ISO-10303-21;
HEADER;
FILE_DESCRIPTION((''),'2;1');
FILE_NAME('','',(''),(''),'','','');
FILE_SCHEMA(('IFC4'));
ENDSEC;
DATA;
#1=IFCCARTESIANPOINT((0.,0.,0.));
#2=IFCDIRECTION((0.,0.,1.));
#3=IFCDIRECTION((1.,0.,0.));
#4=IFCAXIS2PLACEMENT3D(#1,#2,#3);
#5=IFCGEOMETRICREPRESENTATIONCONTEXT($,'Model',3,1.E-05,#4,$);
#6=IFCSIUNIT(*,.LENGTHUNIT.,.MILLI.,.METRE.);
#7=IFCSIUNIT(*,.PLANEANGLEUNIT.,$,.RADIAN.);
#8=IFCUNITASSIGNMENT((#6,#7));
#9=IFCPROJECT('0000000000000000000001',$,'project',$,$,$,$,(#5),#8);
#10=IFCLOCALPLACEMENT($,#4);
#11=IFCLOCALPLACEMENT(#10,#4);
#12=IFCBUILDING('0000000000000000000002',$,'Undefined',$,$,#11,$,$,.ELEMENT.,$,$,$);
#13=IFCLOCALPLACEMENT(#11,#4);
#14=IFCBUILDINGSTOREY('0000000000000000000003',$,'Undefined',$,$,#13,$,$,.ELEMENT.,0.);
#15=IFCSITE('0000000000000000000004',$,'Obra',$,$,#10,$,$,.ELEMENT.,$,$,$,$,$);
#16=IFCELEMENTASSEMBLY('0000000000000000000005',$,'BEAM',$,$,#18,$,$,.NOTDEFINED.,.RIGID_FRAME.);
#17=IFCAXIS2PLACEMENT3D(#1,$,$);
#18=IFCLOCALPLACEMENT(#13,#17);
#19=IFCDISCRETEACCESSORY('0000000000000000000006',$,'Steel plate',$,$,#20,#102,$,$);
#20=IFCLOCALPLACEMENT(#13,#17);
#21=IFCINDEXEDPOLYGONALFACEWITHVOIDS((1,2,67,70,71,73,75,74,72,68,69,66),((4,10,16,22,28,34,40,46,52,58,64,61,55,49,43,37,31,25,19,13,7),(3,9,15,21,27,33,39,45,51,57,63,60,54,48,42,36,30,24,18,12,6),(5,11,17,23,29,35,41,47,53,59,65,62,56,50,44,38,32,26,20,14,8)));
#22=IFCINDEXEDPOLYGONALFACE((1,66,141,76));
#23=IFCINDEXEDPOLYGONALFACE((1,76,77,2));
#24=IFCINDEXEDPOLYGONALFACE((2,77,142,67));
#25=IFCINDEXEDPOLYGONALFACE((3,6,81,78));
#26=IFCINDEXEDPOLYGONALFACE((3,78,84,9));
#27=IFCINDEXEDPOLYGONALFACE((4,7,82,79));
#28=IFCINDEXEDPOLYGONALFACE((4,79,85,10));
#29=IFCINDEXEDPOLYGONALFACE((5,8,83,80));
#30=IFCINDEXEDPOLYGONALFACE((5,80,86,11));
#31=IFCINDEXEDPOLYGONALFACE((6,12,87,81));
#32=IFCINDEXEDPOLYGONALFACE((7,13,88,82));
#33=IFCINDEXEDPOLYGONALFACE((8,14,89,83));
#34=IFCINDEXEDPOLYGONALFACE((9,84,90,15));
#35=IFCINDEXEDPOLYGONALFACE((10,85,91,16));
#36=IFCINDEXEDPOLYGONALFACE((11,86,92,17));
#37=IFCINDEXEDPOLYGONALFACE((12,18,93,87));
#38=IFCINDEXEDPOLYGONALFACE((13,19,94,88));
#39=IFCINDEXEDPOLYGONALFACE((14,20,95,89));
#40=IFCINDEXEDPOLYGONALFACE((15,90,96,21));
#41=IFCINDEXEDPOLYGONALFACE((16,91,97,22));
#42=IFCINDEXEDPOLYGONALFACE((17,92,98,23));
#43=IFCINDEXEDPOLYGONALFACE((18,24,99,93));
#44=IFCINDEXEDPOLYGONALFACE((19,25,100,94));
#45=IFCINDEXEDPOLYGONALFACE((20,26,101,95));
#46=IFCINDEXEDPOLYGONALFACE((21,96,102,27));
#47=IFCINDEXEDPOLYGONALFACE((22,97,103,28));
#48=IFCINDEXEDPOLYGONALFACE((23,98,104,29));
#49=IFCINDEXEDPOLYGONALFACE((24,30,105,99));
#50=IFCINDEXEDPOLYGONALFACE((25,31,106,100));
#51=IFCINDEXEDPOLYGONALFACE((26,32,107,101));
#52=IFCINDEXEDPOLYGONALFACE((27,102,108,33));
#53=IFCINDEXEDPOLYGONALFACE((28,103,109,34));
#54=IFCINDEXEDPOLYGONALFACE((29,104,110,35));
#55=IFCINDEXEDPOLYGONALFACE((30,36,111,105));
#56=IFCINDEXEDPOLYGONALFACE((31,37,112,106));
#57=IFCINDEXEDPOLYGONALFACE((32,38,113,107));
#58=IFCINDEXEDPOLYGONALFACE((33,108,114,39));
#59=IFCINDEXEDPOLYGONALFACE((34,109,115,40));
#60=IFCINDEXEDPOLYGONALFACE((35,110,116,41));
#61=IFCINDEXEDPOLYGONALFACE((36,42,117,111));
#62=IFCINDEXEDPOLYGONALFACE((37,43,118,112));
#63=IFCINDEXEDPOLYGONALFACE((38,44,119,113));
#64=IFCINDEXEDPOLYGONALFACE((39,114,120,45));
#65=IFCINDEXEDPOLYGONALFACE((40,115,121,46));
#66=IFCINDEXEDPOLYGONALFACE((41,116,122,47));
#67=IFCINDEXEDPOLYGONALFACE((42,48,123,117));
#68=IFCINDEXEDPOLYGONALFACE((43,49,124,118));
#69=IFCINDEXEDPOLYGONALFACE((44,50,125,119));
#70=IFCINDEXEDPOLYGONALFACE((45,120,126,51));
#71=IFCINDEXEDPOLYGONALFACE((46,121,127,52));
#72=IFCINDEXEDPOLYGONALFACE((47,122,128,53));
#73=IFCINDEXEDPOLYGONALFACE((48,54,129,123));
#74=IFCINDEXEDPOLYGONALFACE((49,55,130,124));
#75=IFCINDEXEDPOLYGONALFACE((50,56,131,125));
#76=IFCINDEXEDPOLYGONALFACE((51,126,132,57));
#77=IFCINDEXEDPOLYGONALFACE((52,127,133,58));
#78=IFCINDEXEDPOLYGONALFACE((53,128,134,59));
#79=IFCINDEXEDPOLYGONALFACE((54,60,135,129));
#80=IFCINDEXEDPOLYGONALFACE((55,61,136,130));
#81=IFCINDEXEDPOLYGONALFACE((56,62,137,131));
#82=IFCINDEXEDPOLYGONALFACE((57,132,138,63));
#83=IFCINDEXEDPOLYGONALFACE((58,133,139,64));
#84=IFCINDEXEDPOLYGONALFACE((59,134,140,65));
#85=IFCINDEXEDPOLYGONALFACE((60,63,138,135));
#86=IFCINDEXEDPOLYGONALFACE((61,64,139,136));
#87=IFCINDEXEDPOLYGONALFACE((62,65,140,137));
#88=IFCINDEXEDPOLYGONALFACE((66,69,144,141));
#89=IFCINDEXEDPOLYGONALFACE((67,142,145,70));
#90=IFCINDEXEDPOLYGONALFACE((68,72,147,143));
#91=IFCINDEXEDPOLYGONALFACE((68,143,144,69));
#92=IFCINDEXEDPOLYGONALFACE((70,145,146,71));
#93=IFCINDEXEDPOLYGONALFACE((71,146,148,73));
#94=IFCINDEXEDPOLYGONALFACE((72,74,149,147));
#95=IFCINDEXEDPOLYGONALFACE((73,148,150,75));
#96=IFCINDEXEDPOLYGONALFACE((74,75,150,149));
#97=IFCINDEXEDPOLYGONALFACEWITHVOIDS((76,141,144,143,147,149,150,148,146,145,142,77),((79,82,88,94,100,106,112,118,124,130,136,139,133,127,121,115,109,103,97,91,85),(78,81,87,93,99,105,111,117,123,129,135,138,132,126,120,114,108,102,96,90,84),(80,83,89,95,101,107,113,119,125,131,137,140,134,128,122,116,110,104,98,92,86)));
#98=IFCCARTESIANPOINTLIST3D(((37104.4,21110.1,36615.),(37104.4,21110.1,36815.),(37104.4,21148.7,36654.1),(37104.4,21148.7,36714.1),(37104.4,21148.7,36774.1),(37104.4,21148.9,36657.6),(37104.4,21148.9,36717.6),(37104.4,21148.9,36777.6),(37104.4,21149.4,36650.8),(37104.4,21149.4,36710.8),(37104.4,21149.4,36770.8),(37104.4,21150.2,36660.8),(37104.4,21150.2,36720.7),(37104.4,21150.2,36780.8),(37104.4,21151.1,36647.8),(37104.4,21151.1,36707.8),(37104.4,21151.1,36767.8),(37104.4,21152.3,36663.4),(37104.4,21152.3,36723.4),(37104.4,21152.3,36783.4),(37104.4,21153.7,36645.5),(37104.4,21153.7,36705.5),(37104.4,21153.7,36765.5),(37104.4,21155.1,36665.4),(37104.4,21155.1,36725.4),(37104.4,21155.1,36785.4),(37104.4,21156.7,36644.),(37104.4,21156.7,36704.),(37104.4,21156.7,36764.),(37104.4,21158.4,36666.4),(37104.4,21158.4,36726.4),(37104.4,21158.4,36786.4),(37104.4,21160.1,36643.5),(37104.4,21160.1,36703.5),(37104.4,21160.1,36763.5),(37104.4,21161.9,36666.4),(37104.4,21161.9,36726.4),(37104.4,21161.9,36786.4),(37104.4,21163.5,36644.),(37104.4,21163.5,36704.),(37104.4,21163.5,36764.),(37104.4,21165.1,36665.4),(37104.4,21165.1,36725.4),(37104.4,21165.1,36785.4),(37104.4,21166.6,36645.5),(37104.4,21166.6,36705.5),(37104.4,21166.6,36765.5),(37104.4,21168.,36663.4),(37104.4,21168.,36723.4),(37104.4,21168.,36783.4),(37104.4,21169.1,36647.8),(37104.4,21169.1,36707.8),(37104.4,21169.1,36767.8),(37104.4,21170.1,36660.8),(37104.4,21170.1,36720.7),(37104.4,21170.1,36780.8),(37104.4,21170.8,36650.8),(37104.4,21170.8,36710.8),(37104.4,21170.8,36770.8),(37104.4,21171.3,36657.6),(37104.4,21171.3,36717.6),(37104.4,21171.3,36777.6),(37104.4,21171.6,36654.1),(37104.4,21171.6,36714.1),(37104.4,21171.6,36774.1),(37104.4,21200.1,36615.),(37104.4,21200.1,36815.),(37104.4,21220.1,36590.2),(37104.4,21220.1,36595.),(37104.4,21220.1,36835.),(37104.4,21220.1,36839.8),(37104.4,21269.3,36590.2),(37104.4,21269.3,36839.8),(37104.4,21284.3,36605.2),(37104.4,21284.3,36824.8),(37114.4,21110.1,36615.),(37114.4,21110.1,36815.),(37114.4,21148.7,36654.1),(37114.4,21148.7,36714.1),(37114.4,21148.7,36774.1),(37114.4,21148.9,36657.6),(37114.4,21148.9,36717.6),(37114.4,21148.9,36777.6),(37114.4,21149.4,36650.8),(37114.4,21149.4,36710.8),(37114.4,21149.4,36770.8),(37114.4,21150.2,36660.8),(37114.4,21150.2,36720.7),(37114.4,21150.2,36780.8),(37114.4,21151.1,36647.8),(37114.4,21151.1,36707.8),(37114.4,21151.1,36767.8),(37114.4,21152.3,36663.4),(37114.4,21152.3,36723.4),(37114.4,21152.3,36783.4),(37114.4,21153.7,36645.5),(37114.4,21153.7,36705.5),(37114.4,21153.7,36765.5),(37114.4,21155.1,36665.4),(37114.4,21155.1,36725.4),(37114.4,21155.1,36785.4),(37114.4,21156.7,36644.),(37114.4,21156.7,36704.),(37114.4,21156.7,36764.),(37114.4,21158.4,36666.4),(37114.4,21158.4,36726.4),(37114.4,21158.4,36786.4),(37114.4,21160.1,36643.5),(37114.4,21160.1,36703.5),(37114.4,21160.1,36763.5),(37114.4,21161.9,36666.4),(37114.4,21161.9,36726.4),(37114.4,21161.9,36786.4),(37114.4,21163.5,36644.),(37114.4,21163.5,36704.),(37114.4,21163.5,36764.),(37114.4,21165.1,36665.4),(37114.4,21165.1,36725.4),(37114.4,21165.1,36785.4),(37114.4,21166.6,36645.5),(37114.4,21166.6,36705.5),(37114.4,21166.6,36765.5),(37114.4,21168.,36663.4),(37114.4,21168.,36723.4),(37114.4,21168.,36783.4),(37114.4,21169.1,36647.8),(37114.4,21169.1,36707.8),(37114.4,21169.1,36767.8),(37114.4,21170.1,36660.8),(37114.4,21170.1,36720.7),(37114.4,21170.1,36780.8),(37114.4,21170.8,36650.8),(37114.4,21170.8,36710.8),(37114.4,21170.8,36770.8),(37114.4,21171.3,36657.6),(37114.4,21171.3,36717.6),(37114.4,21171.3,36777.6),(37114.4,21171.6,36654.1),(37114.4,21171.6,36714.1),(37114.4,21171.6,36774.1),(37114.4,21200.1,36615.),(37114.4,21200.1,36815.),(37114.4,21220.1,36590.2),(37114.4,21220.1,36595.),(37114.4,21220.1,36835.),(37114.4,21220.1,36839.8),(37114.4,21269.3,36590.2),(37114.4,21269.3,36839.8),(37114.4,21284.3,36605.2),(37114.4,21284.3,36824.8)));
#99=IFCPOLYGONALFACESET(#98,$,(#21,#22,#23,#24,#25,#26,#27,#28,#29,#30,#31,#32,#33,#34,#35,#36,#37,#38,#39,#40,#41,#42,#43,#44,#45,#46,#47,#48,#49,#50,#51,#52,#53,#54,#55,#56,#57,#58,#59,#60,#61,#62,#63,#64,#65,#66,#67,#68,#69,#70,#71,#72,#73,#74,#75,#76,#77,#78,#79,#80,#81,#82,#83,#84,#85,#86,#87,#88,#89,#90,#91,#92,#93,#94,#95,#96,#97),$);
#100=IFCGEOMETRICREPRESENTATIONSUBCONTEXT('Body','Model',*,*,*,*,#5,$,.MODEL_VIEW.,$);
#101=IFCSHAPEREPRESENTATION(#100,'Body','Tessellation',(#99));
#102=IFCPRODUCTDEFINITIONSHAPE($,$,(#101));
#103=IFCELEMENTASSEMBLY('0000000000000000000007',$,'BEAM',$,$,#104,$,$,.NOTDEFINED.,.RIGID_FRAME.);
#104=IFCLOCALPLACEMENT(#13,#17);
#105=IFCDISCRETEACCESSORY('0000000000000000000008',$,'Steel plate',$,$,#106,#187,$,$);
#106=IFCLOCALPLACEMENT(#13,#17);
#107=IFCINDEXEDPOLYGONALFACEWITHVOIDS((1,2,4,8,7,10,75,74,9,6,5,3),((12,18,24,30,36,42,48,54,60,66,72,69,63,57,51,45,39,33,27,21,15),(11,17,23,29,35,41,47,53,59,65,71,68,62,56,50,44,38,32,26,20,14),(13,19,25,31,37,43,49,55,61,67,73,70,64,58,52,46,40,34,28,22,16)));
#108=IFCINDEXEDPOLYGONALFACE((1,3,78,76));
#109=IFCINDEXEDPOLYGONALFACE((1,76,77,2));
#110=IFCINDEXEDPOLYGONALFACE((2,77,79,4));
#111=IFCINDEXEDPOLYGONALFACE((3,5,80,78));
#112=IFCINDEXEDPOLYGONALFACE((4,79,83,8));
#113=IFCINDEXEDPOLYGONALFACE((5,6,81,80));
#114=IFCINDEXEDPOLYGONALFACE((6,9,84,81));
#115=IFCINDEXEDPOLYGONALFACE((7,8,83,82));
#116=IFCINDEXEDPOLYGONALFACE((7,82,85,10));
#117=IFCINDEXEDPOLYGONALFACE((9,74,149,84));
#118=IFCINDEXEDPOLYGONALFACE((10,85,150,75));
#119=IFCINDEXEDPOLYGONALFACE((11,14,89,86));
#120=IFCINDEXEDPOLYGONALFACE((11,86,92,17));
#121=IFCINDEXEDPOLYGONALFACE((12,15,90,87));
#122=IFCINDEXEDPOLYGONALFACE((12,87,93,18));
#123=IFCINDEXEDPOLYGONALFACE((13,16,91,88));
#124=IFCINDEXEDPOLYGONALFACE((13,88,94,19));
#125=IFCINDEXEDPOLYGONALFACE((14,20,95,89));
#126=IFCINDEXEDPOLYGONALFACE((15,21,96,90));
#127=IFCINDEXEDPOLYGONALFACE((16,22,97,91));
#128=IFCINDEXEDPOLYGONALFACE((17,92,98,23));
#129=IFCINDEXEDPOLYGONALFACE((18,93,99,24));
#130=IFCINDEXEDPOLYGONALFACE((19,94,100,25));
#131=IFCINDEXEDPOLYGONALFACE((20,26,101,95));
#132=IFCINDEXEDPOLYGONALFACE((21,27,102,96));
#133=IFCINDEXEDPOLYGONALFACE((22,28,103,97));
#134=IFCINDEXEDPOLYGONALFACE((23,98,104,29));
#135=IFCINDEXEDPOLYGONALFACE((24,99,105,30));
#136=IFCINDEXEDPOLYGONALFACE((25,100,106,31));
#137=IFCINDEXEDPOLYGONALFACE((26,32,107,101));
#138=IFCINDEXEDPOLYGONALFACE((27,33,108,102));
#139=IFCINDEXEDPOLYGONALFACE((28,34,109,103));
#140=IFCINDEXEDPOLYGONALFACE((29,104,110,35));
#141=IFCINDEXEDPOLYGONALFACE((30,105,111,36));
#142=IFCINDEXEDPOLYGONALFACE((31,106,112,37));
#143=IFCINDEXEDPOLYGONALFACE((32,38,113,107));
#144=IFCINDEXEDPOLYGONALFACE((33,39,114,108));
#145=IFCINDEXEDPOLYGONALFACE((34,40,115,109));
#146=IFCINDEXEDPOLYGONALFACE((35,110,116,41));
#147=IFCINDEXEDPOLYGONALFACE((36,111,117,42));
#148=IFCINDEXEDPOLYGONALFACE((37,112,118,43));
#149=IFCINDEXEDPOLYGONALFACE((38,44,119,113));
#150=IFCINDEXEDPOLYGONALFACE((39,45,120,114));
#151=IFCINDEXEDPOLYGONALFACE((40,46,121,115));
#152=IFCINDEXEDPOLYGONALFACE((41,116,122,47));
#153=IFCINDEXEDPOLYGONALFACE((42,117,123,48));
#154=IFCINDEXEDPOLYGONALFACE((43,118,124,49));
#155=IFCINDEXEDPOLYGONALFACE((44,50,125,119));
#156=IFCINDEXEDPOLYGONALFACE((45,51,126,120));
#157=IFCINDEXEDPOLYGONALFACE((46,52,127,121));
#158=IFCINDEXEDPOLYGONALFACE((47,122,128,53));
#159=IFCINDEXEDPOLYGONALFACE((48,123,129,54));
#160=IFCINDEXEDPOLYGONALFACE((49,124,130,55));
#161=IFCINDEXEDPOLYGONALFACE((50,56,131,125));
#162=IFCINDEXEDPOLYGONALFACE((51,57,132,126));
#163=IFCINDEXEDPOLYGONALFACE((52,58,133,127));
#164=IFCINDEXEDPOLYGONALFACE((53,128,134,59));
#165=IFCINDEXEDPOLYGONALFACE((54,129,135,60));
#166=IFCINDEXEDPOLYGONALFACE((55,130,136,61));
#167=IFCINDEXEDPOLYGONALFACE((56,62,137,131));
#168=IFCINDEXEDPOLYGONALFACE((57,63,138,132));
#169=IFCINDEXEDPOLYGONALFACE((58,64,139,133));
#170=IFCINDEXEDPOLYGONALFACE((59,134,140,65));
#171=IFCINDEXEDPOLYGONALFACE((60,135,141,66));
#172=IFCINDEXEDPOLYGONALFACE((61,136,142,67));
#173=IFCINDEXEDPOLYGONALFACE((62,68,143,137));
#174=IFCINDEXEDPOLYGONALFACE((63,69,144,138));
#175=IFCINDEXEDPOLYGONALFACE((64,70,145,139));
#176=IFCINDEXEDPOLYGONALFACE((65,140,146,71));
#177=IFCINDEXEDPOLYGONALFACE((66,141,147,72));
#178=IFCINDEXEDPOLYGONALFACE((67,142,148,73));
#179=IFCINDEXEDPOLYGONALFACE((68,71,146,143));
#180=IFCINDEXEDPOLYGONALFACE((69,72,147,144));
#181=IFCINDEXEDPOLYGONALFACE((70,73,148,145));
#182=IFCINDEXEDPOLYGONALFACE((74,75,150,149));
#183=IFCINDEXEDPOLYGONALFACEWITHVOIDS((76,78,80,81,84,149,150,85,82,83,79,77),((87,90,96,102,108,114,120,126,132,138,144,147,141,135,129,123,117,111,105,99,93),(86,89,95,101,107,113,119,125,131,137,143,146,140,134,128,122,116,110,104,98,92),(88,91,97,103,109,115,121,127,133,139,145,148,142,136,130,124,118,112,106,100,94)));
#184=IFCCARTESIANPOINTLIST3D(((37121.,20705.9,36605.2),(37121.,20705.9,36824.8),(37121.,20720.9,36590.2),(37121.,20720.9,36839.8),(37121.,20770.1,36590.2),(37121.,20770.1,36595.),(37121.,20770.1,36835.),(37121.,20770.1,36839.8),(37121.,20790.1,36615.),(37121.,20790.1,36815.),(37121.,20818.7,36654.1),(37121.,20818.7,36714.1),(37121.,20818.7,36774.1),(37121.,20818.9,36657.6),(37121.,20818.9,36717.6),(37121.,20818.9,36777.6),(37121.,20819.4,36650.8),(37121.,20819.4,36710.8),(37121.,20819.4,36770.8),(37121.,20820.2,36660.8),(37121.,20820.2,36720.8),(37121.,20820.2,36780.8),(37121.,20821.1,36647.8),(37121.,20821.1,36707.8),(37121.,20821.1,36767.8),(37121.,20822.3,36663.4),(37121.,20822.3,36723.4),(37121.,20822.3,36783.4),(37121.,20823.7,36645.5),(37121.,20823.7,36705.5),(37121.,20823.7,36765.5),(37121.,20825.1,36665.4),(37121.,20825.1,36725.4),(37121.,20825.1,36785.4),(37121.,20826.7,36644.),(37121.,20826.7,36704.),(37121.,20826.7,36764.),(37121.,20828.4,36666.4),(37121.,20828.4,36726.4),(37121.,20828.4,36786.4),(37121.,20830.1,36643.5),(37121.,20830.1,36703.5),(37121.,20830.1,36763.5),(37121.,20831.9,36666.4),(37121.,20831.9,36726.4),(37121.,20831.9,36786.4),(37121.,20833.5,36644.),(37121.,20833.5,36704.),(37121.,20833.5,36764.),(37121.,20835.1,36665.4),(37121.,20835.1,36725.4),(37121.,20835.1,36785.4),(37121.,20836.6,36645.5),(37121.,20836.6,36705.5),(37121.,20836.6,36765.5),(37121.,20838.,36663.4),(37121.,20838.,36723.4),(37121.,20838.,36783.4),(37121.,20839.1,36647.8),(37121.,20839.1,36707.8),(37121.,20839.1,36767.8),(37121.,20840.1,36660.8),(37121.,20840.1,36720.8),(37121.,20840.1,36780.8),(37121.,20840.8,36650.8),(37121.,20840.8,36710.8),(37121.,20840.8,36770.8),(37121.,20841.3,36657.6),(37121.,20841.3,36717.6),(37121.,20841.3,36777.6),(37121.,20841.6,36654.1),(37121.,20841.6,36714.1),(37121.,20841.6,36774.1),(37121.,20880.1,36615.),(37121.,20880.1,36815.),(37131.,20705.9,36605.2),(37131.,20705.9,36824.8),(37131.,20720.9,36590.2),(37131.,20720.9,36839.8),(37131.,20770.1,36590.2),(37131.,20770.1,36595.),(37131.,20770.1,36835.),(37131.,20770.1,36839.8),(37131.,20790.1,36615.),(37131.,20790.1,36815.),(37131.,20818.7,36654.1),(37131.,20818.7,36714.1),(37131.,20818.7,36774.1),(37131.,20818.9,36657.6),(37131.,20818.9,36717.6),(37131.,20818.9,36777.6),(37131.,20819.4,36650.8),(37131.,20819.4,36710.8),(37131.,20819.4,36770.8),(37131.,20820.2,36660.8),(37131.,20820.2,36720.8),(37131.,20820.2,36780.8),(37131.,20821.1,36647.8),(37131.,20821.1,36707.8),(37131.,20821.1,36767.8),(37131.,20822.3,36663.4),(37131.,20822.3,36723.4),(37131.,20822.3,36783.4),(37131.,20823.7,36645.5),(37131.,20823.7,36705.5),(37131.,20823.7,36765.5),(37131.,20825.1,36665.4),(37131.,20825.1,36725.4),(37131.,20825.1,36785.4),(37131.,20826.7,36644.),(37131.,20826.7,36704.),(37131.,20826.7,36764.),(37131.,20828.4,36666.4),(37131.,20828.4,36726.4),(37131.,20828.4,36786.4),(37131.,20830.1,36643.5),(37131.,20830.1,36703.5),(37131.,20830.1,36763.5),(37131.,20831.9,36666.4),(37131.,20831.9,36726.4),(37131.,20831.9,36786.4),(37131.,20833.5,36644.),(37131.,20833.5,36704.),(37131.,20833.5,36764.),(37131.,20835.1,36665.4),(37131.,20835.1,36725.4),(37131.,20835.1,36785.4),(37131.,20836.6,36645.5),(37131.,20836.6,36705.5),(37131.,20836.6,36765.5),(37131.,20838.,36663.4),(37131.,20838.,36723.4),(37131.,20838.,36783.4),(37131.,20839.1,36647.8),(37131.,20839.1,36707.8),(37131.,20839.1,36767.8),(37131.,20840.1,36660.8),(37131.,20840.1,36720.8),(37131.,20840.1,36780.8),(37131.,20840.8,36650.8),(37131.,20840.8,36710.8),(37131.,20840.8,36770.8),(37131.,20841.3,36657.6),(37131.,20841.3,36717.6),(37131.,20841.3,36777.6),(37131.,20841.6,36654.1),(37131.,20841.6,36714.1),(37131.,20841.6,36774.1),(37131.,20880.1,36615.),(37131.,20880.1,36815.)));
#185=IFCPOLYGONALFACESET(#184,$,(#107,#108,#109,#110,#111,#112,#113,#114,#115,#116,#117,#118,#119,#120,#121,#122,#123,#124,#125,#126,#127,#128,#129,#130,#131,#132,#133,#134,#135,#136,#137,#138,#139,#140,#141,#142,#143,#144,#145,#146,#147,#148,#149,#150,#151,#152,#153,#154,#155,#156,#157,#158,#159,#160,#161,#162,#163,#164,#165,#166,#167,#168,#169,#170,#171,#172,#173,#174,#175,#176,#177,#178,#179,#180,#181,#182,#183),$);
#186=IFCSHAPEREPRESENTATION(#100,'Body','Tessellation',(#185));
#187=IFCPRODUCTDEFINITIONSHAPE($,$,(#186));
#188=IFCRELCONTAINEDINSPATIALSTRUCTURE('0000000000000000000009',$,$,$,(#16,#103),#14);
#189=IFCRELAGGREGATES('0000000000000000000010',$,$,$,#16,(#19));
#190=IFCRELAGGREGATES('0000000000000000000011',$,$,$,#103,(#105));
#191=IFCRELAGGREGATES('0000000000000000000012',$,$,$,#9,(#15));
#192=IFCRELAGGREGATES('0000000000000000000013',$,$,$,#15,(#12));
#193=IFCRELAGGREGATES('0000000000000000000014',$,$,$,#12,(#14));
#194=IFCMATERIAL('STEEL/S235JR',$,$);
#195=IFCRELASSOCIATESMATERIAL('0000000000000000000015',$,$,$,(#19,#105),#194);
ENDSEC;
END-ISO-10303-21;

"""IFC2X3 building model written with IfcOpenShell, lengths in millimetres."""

from ifc_helpers import new_model, si_unit, frame, origin_with_axes, origin_2d_with_axis, place, context, subcontext, project, spatial, polyline, circle, outline, extrude, source, transform, mapped, material, element, aggregate, save


model = new_model("IFC2X3")

# Units and contexts
model_context = context("Model", 3, precision=1e-05, world=origin_with_axes())
body_context = subcontext(model_context, "Body", "Model", "MODEL_VIEW")
ifc_project = project(units=[si_unit("LENGTHUNIT", "METRE", prefix="MILLI"), si_unit("PLANEANGLEUNIT", "RADIAN")], contexts=[model_context])

# Site, building, storey
site_placement = place(None, origin_with_axes())
site = spatial("IfcSite", under=ifc_project, at=site_placement, Name="Obra", CompositionType="ELEMENT")
building_placement = place(site_placement, origin_with_axes())
building = spatial("IfcBuilding", under=site, at=building_placement, Name="Undefined", CompositionType="ELEMENT")
storey_placement = place(building_placement, origin_with_axes())
storey = spatial("IfcBuildingStorey", under=building, at=storey_placement, Name="Undefined", CompositionType="ELEMENT", Elevation=0.0)

# Shared definitions
ifc_material_1 = material(Name="STEEL/S235JR")

# Element assemblies, discrete accessories, openings
assembly_1_placement = place(storey_placement, origin_with_axes())
assembly_1 = element("IfcElementAssembly", 1, at=assembly_1_placement, inside=storey, Name="BEAM", AssemblyPlace="NOTDEFINED", PredefinedType="RIGID_FRAME")
discrete_accessory_1_placement = place(assembly_1_placement, frame((37109.4, 21284.3, 36605.2), z_axis=(-1.0, 0.0, 0.0), x_axis=(0.0, -0.707107, -0.707107)))
discrete_accessory_1 = element("IfcDiscreteAccessory", 2, at=discrete_accessory_1_placement, material=ifc_material_1, Name="Steel plate", context=body_context, shape_type="SweptSolid", body=[
    extrude(outline(polyline([(0.0, 0.0), (21.2, 0.0), (56.0, 34.8), (52.6, 38.2), (52.6, 66.5), (116.2, 130.1), (-25.2, 271.5), (-88.8, 207.9), (-117.1, 207.9), (-120.5, 211.3), (-155.3, 176.5), (-155.3, 155.3), (0.0, 0.0)])), frame((0.0, 0.0, -5.0), z_axis=(0.0, 0.0, 1.0), x_axis=(1.0, 0.0, 0.0)), (0.0, 0.0, 1.0), 10.0),
])
shared_shape_1 = source(origin_with_axes(), body_context, "Body", "SweptSolid", [
    extrude(circle(Radius=11.5, at=origin_2d_with_axis()), frame((0.0, -13.4, 0.0), z_axis=(0.0, 1.0, 0.0), x_axis=(1.0, 0.0, 0.0)), (0.0, 0.0, 1.0), 10.2),
])
opening_1_placement = place(assembly_1_placement, frame((37117.7, 21210.1, 36815.0), z_axis=(0.0, -1.0, 0.0), x_axis=(0.0, 0.0, -1.0)))
element("IfcOpeningElement", 3, at=opening_1_placement, cuts=discrete_accessory_1, ObjectType="Opening", context=body_context, shape_type="MappedRepresentation", body=[
    mapped(shared_shape_1, transform((40.0, 0.0, 50.0))),
    mapped(shared_shape_1, transform((100.0, 0.0, 50.0))),
    mapped(shared_shape_1, transform((160.0, 0.0, 50.0))),
])
aggregate(assembly_1, [discrete_accessory_1])
assembly_2_placement = place(storey_placement, origin_with_axes())
assembly_2 = element("IfcElementAssembly", 4, at=assembly_2_placement, inside=storey, Name="BEAM", AssemblyPlace="NOTDEFINED", PredefinedType="RIGID_FRAME")
discrete_accessory_2_placement = place(assembly_2_placement, frame((37126.0, 20705.9, 36605.2), z_axis=(1.0, 0.0, 0.0), x_axis=(0.0, 0.707107, -0.707107)))
discrete_accessory_2 = element("IfcDiscreteAccessory", 5, at=discrete_accessory_2_placement, material=ifc_material_1, Name="Steel plate", context=body_context, shape_type="SweptSolid", body=[
    extrude(outline(polyline([(0.0, 0.0), (21.2, 0.0), (56.0, 34.8), (52.6, 38.2), (52.6, 66.5), (116.2, 130.1), (-25.2, 271.5), (-88.8, 207.9), (-117.1, 207.9), (-120.5, 211.3), (-155.3, 176.5), (-155.3, 155.3), (0.0, 0.0)])), frame((0.0, 0.0, -5.0), z_axis=(0.0, 0.0, 1.0), x_axis=(1.0, 0.0, 0.0)), (0.0, 0.0, 1.0), 10.0),
])
opening_2_placement = place(assembly_2_placement, frame((37117.7, 20780.1, 36815.0), z_axis=(0.0, 1.0, 0.0), x_axis=(0.0, 0.0, -1.0)))
element("IfcOpeningElement", 6, at=opening_2_placement, cuts=discrete_accessory_2, ObjectType="Opening", context=body_context, shape_type="MappedRepresentation", body=[
    mapped(shared_shape_1, transform((40.0, 0.0, 50.0))),
    mapped(shared_shape_1, transform((100.0, 0.0, 50.0))),
    mapped(shared_shape_1, transform((160.0, 0.0, 50.0))),
])
aggregate(assembly_2, [discrete_accessory_2])

save(model, "model.ifc")
